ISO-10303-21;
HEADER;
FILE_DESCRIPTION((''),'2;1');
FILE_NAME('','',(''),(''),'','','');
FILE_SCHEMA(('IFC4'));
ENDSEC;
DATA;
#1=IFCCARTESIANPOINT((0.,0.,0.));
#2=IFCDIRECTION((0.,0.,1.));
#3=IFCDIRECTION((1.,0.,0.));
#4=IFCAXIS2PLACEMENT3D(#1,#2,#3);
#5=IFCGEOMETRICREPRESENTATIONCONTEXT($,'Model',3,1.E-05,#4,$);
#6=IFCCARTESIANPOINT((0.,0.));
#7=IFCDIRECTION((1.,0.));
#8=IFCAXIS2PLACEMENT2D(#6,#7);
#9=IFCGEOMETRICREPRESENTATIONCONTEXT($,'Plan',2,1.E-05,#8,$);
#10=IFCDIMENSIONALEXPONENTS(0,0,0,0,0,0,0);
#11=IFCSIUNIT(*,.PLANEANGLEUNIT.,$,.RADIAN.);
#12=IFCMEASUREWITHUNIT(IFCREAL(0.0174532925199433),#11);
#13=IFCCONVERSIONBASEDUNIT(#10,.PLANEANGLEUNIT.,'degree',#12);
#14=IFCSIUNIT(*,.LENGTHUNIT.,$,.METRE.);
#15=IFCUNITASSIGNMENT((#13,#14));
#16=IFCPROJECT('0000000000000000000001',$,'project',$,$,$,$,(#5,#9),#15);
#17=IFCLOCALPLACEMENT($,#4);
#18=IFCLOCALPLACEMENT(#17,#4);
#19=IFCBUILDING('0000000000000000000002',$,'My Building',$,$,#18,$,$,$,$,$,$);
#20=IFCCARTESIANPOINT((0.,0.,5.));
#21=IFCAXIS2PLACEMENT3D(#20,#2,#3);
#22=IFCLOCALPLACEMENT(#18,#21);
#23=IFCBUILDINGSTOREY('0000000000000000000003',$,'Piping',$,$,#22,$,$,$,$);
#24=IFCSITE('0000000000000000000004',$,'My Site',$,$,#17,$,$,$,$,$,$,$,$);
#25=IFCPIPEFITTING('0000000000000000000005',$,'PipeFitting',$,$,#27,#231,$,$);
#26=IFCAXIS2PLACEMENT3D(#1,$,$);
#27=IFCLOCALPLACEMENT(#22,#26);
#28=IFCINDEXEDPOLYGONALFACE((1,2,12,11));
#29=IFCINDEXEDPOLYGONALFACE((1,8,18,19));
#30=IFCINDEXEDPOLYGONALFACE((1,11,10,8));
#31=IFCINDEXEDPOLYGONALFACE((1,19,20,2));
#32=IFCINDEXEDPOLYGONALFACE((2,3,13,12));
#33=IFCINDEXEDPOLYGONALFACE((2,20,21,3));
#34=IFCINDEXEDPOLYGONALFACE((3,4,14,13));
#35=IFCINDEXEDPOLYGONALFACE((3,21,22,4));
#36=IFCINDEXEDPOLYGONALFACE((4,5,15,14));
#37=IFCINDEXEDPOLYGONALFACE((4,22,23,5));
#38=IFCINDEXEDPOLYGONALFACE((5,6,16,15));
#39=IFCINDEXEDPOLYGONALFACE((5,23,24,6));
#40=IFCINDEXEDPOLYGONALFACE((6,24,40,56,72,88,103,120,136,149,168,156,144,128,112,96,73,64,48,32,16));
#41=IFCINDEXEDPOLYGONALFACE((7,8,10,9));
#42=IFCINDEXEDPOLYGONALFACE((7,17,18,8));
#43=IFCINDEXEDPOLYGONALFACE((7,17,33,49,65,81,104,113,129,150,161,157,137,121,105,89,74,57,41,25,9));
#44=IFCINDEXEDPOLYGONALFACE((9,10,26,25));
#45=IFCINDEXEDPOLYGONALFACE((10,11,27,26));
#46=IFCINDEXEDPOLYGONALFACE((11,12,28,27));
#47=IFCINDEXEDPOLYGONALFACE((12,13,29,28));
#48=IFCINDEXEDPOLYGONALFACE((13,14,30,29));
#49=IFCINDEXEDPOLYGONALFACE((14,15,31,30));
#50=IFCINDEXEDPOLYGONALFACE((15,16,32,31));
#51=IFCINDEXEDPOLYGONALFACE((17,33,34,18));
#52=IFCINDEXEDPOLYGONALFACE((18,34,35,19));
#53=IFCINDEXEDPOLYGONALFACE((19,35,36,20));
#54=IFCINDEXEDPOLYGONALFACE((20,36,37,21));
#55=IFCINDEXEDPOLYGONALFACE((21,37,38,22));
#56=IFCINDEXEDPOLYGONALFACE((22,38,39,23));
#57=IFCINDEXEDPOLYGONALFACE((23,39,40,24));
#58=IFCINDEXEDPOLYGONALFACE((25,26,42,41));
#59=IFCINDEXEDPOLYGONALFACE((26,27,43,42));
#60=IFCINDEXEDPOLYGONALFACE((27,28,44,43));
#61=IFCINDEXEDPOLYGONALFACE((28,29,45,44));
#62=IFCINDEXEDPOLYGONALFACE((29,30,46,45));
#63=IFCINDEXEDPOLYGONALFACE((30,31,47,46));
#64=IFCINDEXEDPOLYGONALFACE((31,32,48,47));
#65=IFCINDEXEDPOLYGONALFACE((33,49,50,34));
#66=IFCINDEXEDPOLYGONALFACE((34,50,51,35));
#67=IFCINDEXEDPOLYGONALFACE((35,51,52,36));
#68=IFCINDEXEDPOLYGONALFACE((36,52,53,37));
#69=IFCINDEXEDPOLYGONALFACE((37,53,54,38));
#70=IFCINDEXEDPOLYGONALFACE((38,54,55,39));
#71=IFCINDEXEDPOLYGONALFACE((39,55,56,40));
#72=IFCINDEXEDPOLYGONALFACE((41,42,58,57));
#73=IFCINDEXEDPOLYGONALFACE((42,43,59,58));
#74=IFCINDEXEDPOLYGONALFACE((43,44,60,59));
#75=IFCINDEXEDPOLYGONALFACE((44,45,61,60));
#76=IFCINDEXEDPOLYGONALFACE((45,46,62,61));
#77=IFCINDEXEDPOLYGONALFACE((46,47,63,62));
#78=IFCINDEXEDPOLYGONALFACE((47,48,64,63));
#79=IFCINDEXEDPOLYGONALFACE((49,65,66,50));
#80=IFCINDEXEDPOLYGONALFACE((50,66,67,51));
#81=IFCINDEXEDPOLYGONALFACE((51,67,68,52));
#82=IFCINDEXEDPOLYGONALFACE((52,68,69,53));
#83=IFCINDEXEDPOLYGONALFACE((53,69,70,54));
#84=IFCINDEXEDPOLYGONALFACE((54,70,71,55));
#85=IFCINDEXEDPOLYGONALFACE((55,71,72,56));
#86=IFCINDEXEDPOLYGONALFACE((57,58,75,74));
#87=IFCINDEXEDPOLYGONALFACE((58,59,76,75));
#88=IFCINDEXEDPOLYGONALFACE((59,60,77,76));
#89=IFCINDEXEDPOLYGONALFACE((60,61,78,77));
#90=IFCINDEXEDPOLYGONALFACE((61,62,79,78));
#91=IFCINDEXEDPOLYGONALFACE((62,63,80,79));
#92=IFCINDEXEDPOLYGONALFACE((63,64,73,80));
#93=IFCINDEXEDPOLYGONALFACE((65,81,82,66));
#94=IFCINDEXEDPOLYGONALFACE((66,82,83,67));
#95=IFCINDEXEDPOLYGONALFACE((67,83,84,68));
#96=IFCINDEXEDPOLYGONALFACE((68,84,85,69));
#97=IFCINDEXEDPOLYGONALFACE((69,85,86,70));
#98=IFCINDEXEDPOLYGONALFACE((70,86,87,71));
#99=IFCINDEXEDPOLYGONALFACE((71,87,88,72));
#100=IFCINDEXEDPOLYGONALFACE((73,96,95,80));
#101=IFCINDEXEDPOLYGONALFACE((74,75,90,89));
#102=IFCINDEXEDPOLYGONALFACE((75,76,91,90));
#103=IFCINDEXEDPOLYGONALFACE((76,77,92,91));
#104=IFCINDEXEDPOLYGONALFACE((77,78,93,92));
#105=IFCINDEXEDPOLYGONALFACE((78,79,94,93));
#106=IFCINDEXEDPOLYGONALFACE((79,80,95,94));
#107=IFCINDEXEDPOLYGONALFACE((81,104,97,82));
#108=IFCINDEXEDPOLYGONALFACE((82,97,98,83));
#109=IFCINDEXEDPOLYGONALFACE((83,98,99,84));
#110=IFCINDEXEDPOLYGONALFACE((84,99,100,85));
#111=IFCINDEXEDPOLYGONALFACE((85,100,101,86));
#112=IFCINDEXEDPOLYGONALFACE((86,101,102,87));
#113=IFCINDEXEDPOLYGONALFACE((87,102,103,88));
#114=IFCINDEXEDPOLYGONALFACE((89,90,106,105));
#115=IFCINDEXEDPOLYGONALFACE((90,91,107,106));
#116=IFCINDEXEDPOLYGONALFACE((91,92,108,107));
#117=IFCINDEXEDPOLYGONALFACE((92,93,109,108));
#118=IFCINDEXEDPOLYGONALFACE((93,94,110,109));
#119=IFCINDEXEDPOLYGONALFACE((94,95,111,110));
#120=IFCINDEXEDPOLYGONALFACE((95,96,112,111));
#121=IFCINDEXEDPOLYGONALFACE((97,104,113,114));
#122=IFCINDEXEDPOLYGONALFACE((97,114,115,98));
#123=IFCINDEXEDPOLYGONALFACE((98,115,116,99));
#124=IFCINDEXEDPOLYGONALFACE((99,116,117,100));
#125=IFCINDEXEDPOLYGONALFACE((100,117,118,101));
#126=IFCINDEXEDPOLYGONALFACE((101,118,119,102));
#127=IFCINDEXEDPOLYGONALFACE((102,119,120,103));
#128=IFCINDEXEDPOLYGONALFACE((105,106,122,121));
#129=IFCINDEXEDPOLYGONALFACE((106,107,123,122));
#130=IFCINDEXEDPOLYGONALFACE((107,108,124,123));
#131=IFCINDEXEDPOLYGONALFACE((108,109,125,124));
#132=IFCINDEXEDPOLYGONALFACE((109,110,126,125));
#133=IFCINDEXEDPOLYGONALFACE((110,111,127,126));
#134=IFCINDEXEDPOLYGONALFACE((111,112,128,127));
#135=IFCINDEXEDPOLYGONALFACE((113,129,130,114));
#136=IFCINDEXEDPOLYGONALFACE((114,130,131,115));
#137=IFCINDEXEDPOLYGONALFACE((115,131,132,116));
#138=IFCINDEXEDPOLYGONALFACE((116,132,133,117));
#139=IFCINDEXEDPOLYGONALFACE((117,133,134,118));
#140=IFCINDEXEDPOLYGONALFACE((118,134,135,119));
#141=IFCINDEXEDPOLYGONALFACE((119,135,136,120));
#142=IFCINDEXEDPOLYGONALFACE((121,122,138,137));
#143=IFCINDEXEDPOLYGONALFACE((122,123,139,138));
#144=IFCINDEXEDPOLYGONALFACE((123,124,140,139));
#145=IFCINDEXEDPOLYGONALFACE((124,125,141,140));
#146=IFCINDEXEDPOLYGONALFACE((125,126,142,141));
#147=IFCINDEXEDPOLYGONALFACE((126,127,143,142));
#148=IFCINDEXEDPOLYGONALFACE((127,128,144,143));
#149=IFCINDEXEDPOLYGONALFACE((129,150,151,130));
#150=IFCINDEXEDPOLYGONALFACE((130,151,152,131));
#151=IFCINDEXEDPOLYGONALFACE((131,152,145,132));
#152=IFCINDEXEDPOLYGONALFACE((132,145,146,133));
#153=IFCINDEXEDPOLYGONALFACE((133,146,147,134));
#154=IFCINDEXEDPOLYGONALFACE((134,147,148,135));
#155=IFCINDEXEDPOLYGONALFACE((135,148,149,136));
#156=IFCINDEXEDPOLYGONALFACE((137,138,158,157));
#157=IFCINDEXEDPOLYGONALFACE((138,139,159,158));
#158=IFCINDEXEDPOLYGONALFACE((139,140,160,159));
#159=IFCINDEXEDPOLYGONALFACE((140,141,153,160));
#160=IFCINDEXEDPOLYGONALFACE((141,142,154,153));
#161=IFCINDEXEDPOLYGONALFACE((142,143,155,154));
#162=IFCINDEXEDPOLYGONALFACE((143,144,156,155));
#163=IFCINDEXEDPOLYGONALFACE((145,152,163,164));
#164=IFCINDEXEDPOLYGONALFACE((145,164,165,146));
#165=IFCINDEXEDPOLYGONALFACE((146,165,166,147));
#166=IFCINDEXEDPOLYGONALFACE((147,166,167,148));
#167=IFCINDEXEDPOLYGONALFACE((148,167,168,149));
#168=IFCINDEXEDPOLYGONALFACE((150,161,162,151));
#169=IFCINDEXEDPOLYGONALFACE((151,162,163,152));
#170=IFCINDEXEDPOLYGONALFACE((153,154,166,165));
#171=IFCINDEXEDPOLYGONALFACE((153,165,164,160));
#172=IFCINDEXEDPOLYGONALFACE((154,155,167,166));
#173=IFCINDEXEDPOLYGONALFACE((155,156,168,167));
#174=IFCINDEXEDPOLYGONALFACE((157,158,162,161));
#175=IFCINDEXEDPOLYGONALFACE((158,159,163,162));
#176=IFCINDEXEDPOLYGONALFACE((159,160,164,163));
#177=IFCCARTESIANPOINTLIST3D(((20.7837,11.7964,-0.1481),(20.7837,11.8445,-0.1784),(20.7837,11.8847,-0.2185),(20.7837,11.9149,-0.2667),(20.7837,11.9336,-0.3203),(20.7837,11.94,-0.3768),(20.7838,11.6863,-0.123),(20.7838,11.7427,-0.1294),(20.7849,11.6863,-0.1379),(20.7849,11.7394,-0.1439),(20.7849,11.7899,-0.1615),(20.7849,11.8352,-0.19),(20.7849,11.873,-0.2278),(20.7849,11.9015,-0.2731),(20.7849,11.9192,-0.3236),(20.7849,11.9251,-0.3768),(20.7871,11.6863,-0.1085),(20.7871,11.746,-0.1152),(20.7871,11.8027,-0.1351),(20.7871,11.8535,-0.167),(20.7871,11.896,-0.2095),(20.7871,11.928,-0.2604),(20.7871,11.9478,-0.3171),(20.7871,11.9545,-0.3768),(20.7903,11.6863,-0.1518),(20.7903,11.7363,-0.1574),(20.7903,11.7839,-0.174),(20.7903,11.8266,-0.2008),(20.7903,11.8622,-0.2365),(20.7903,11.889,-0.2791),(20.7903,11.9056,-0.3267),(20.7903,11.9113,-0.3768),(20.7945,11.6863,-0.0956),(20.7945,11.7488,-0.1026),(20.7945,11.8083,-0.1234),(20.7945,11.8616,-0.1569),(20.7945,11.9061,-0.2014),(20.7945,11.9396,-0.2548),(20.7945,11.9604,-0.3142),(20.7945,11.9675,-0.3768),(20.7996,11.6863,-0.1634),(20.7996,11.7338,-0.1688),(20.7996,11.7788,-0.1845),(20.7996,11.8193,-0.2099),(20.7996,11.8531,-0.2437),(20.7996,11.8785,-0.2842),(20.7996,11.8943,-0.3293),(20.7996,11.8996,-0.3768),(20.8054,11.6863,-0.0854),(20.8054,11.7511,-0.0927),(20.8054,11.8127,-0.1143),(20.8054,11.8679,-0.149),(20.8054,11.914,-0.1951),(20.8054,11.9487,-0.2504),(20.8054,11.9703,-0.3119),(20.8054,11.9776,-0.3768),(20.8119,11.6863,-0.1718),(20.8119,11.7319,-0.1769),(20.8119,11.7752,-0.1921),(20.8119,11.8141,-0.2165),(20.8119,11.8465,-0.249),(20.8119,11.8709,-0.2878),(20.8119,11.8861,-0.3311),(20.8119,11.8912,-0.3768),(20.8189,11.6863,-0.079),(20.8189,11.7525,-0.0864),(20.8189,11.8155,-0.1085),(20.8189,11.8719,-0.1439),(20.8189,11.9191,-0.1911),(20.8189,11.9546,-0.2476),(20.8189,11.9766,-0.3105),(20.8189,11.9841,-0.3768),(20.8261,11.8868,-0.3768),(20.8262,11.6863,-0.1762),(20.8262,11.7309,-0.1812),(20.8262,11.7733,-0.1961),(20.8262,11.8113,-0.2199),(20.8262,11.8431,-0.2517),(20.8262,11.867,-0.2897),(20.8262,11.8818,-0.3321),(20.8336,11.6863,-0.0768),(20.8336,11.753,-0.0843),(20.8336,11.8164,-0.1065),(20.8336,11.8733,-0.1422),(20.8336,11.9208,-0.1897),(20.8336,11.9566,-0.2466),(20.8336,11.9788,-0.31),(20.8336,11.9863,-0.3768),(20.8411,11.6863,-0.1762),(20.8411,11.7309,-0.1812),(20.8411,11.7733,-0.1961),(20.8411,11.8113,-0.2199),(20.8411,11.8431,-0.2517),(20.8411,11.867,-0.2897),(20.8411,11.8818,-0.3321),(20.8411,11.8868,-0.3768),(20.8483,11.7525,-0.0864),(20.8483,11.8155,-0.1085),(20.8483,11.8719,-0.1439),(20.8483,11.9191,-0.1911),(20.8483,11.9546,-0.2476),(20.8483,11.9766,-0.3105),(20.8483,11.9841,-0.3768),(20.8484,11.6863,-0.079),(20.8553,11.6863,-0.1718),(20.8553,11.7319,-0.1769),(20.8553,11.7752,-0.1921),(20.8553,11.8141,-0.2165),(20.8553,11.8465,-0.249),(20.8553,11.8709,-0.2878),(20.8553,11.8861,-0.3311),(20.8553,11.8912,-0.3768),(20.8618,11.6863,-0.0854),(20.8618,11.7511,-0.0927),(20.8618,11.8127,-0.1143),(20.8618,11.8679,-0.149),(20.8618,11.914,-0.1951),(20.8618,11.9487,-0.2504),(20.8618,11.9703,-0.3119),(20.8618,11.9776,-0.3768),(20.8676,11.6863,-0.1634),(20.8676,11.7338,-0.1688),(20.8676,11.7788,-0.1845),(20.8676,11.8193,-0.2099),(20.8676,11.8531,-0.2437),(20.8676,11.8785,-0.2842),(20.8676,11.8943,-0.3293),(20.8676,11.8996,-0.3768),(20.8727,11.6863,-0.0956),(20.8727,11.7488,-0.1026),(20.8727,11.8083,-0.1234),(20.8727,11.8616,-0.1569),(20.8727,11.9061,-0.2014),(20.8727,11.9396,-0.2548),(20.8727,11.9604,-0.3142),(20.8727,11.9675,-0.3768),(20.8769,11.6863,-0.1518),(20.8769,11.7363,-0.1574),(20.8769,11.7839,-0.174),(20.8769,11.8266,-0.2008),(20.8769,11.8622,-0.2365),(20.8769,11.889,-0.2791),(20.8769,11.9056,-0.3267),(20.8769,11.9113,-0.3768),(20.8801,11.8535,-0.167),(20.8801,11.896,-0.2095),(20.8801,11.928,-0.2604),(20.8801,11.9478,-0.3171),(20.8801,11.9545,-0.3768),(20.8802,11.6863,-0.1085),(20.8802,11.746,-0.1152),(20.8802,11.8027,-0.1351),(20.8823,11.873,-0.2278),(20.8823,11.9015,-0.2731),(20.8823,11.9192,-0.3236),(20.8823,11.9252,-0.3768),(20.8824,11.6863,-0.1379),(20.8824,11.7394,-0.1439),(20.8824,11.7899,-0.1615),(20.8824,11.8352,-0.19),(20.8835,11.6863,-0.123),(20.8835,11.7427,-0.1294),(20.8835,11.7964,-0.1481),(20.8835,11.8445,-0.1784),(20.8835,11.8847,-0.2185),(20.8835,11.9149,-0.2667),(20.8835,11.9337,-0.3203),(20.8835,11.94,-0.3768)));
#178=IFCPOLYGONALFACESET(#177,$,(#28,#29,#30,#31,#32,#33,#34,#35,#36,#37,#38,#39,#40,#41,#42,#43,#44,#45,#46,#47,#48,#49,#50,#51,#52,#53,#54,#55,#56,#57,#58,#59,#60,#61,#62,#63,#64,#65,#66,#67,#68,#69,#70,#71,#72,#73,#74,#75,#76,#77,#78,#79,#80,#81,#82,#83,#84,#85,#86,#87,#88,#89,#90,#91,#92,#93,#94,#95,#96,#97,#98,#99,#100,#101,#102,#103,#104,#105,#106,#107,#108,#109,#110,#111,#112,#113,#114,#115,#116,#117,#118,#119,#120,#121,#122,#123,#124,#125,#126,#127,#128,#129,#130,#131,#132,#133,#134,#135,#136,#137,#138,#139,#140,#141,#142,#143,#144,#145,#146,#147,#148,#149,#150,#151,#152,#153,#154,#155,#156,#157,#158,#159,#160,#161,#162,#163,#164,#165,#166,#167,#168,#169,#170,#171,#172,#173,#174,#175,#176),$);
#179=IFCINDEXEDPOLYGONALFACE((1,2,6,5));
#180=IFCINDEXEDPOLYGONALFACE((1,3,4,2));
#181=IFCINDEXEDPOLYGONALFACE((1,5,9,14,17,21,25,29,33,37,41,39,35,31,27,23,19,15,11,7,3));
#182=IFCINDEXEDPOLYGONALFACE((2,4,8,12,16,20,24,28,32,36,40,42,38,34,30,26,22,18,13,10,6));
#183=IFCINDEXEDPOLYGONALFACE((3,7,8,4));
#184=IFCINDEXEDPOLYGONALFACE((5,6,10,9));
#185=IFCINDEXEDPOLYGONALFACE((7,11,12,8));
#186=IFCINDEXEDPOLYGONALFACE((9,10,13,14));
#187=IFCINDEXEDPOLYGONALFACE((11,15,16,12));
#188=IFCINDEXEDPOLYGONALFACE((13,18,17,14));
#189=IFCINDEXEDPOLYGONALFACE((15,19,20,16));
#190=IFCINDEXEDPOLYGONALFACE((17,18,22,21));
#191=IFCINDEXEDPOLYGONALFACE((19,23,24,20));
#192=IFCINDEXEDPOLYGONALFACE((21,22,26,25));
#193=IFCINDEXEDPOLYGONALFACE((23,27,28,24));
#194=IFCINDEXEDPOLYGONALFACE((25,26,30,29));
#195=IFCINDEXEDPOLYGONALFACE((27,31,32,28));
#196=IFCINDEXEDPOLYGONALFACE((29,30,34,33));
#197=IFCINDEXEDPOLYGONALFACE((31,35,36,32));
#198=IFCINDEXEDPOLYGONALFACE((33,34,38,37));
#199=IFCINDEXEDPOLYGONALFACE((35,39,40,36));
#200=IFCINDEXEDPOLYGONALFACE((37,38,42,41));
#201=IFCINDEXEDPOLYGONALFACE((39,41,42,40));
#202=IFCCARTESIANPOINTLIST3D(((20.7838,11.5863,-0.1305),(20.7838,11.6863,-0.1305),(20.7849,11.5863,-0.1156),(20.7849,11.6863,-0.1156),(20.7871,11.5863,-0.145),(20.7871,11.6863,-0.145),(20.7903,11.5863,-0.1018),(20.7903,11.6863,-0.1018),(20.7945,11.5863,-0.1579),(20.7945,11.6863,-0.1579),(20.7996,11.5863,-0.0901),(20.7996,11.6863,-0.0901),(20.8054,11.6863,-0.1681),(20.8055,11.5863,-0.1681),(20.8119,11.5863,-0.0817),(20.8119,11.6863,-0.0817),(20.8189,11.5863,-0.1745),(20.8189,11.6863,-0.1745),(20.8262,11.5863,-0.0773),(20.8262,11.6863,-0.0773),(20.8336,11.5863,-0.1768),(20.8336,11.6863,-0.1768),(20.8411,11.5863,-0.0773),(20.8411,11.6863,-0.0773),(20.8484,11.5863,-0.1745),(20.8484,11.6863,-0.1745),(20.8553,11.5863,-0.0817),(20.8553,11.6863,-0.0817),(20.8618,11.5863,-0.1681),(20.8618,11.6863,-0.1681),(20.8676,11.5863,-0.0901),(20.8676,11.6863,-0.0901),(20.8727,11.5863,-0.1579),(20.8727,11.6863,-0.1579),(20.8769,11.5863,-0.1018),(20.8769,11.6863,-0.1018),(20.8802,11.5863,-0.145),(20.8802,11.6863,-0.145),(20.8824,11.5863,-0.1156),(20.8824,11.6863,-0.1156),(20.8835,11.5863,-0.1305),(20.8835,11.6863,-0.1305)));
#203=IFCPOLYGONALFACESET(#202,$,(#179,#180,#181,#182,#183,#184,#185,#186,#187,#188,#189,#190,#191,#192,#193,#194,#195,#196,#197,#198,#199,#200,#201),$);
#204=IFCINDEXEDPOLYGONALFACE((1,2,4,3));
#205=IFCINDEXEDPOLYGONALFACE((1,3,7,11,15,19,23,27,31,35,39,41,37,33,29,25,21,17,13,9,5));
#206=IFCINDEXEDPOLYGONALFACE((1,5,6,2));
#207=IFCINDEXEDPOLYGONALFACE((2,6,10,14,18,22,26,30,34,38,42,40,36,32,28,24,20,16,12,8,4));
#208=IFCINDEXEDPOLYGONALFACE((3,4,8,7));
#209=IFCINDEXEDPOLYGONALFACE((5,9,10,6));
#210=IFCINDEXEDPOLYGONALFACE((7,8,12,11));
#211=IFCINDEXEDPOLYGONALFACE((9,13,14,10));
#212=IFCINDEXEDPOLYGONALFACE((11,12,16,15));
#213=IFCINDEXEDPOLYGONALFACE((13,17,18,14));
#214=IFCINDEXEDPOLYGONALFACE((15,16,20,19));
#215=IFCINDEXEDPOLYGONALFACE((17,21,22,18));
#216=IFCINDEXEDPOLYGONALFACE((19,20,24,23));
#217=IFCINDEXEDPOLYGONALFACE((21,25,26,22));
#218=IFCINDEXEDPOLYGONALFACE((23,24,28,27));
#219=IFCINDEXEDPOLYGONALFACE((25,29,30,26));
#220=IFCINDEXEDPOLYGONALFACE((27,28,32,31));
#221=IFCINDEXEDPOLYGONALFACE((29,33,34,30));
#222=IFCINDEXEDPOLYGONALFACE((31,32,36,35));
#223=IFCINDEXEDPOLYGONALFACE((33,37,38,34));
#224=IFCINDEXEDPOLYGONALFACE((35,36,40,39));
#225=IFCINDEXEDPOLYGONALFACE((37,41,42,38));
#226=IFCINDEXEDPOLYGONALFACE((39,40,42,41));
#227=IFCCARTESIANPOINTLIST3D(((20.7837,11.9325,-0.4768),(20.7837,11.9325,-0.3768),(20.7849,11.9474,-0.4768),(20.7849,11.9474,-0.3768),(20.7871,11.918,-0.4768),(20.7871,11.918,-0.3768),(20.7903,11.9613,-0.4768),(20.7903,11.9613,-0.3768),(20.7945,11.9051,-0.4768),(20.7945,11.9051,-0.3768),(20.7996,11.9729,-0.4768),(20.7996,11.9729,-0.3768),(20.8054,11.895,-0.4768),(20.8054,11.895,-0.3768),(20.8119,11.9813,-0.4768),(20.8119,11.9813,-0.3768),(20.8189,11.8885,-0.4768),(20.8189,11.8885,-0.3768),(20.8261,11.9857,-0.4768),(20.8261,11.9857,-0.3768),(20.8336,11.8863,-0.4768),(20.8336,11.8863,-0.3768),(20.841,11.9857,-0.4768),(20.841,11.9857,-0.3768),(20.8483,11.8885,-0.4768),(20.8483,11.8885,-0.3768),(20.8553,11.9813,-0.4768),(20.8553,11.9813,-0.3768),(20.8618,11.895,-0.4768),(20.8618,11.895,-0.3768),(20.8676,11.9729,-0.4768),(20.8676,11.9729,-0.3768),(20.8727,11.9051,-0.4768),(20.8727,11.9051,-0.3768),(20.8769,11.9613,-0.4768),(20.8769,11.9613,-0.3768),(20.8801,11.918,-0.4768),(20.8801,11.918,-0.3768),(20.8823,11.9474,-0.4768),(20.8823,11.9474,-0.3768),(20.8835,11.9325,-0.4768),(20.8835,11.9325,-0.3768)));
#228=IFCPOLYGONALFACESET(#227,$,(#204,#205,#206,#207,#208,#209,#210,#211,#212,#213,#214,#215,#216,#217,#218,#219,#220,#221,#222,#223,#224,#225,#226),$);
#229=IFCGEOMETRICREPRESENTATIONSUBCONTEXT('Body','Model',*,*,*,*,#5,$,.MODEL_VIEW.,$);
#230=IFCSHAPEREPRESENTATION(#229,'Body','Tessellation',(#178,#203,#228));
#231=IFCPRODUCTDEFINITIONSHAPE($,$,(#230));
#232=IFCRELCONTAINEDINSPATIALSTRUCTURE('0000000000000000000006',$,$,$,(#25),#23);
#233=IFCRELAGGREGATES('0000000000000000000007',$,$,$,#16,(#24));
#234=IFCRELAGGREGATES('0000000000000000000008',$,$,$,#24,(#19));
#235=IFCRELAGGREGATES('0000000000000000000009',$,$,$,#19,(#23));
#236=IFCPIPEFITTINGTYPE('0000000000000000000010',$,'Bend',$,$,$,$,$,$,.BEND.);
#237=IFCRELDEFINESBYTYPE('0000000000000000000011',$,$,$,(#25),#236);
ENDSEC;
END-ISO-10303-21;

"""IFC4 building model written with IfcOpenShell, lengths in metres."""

from ifc_helpers import new_model, entity, si_unit, converted_unit, frame, origin_with_axes, origin_2d_with_axis, place, context, subcontext, project, spatial, circle, extrude, source, transform, mapped, type_object, type_shapes, element, save


model = new_model("IFC4")

# Units and contexts
model_context = context("Model", 3, precision=1e-05, world=origin_with_axes())
plan_context = context("Plan", 2, precision=1e-05, world=origin_2d_with_axis())
body_context = subcontext(model_context, "Body", "Model", "MODEL_VIEW")
ifc_project = project(units=[converted_unit("PLANEANGLEUNIT", "degree", entity("IfcReal", 0.0174532925199433), si_unit("PLANEANGLEUNIT", "RADIAN"), dimensions=[0, 0, 0, 0, 0, 0, 0]), si_unit("LENGTHUNIT", "METRE")], contexts=[model_context, plan_context])

# Site, building, storey
site_placement = place(None, origin_with_axes())
site = spatial("IfcSite", under=ifc_project, at=site_placement, Name="My Site")
building_placement = place(site_placement, origin_with_axes())
building = spatial("IfcBuilding", under=site, at=building_placement, Name="My Building")
storey_placement = place(building_placement, frame((0.0, 0.0, 5.0), z_axis=(0.0, 0.0, 1.0), x_axis=(1.0, 0.0, 0.0)))
storey = spatial("IfcBuildingStorey", under=building, at=storey_placement, Name="Piping")

# Pipe fitting
pipe_fitting_type_1 = type_object("IfcPipeFittingType", Name="Bend", PredefinedType="BEND")
shared_shape = source(origin_with_axes(), body_context, "Body", "SolidModel", [
    entity("IfcSweptDiskSolid", entity("IfcIndexedPolyCurve", entity("IfcCartesianPointList3D", [[0.0, 0.0, -0.1], [0.0732, 0.0, -0.2768], [0.25, 0.0, -0.35]]), [entity("IfcArcIndex", [1, 2, 3])]), 0.05),
    extrude(circle(Radius=0.05), origin_with_axes(), (0.0, 0.0, -1.0), 0.1),
    extrude(circle(Radius=0.05), frame((0.25, 0.0, -0.35), z_axis=(1.0, 0.0, 0.0), x_axis=(0.0, 0.0, 1.0)), (0.0, 0.0, 1.0), 0.1),
])
type_shapes(pipe_fitting_type_1, [shared_shape])
for number, where, z_axis, x_axis, name in (
    (1, (20.8336, 11.5863, -0.1268), (0.00006, -1.0, 0.0), (0.0, 0.0, -1.0), "PipeFitting"),
):
    element("IfcPipeFitting", number, at=place(storey_placement, frame(where, z_axis=z_axis, x_axis=x_axis)), inside=storey, type_object=pipe_fitting_type_1, Name=name, context=body_context, shape_type="MappedRepresentation", body=[
        mapped(shared_shape, transform((0.0, 0.0, 0.0), x_axis=(1.0, 0.0, 0.0), y_axis=(0.0, 1.0, 0.0), z_axis=(0.0, 0.0, 1.0), scale=1.0)),
    ])

save(model, "model.ifc")
